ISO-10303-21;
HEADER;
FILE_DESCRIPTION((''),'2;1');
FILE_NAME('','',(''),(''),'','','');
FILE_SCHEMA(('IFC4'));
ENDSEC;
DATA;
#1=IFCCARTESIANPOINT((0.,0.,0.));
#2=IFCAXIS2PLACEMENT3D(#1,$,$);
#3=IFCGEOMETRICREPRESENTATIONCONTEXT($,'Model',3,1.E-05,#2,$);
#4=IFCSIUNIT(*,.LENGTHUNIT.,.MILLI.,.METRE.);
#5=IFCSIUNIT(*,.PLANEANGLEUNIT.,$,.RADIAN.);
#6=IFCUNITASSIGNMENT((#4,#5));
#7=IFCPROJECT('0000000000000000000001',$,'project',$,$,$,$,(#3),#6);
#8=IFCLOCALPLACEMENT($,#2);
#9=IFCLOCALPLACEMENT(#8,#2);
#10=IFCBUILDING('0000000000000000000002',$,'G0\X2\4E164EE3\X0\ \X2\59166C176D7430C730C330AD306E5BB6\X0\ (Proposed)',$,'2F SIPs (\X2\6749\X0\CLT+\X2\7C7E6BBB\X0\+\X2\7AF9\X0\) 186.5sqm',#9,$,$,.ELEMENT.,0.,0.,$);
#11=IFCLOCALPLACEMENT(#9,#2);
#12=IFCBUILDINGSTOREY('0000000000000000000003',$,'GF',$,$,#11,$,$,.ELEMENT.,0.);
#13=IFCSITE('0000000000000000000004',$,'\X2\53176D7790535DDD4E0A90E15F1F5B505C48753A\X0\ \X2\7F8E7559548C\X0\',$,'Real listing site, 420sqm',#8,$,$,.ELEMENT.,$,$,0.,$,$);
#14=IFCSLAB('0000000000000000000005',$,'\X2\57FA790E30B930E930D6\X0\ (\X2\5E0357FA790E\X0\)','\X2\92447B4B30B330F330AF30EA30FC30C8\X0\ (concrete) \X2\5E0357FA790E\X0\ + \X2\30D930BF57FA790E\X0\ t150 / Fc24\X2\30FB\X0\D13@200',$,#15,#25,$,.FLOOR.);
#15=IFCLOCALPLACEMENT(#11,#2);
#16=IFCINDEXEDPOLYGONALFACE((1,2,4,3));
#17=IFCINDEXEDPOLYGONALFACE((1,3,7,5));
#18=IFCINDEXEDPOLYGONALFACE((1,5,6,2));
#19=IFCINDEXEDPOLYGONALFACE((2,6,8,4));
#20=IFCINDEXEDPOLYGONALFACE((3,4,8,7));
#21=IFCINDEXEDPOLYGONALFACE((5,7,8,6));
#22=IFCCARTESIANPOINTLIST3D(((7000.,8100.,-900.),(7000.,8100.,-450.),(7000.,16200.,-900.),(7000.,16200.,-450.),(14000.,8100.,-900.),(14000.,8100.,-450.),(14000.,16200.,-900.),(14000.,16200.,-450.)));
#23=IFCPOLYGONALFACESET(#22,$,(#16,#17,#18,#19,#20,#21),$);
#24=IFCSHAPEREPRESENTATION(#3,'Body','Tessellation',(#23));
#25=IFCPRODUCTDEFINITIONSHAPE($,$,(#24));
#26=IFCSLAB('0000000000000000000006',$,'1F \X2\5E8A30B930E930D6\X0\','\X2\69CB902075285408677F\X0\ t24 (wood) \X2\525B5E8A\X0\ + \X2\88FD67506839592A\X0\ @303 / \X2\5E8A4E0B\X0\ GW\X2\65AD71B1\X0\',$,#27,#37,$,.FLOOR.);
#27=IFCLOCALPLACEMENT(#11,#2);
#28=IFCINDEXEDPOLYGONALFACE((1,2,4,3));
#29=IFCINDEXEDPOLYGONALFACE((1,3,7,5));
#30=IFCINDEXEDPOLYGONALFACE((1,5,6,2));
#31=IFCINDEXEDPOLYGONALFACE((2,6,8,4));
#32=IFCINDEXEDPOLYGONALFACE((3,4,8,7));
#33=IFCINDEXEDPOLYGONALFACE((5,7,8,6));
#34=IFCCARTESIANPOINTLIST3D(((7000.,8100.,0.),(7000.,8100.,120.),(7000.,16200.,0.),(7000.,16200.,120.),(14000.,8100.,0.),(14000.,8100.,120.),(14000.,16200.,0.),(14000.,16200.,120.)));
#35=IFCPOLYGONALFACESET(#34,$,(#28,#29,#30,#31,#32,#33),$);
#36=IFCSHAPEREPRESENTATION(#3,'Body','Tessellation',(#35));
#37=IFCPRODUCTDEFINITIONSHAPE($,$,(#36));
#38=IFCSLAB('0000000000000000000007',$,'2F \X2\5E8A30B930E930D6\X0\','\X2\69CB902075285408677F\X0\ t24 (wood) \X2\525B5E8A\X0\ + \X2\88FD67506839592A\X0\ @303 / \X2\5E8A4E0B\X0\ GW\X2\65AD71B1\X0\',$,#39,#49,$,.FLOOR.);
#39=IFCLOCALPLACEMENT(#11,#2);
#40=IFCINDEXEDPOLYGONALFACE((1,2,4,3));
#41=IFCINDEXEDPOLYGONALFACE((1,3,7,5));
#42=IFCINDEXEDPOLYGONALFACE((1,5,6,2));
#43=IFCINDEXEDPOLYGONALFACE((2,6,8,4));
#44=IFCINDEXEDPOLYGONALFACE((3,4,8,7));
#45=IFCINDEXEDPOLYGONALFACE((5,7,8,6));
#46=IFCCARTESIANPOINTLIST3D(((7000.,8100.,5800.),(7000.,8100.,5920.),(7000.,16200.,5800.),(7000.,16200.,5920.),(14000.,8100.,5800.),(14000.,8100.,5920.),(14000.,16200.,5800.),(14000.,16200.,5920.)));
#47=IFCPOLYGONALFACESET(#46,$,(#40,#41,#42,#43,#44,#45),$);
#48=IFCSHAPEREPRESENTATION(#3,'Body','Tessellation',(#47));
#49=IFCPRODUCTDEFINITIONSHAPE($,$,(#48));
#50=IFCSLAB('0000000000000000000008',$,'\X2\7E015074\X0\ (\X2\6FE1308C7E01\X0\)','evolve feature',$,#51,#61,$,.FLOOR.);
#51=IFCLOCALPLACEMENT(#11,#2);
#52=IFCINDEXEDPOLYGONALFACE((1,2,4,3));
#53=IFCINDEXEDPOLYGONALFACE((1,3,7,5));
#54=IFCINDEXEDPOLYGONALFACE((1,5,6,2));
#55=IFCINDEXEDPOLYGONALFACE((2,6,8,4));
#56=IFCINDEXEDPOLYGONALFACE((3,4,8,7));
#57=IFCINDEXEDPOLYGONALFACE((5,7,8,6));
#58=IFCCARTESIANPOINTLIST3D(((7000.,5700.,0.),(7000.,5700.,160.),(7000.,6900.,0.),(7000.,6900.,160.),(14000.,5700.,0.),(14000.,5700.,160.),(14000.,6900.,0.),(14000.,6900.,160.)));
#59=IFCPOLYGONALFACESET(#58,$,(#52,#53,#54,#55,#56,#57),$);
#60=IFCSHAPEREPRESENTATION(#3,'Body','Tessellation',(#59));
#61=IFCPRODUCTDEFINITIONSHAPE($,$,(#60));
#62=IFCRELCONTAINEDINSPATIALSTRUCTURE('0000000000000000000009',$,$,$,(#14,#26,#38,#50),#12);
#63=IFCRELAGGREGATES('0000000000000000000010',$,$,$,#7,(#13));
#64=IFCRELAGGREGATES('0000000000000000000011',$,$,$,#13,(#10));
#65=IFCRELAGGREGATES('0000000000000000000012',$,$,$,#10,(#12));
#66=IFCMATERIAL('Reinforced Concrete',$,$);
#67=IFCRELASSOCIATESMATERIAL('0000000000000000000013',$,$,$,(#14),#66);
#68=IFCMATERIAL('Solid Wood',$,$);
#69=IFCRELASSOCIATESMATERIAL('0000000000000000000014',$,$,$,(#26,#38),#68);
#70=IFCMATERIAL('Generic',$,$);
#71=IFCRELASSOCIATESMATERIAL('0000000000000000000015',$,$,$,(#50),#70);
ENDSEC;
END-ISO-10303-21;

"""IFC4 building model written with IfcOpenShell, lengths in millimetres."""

from ifc_helpers import new_model, si_unit, frame, frame_2d, origin, place, context, project, spatial, rectangle, extrude, material, element, save


model = new_model("IFC4")

# Units and contexts
model_context = context("Model", 3, precision=1e-05, world=origin())
ifc_project = project(units=[si_unit("LENGTHUNIT", "METRE", prefix="MILLI"), si_unit("PLANEANGLEUNIT", "RADIAN")], contexts=[model_context])

# Site, building, storey
site_placement = place(None, origin())
site = spatial("IfcSite", under=ifc_project, at=site_placement, Name="北海道川上郡弟子屈町 美留和", ObjectType="Real listing site, 420sqm", CompositionType="ELEMENT", RefElevation=0.0)
building_placement = place(site_placement, origin())
building = spatial("IfcBuilding", under=site, at=building_placement, Name="G0世代 外気浴デッキの家 (Proposed)", ObjectType="2F SIPs (杉CLT+籾殻+竹) 186.5sqm", CompositionType="ELEMENT", ElevationOfRefHeight=0.0, ElevationOfTerrain=0.0)
storey_placement = place(building_placement, origin())
storey = spatial("IfcBuildingStorey", under=building, at=storey_placement, Name="GF", CompositionType="ELEMENT", Elevation=0.0)

# Slabs
ifc_material_1 = material(Name="Reinforced Concrete")
slab_1_placement = place(storey_placement, frame((3500.0, 4050.0, -450.0)))
element("IfcSlab", 1, at=slab_1_placement, inside=storey, material=ifc_material_1, Name="基礎スラブ (布基礎)", Description="鉄筋コンクリート (concrete) 布基礎 + ベタ基礎 t150 / Fc24・D13@200", PredefinedType="FLOOR", context=model_context, shape_type="SweptSolid", body=[
    extrude(rectangle(XDim=7000.0, YDim=8100.0, at=frame_2d((3500.0, 4050.0))), frame((3500.0, 4050.0, -450.0)), (0.0, 0.0, 1.0), 450.0),
])
ifc_material_2 = material(Name="Solid Wood")
slab_2_placement = place(storey_placement, frame((3500.0, 4050.0, 0.0)))
element("IfcSlab", 2, at=slab_2_placement, inside=storey, material=ifc_material_2, Name="1F 床スラブ", Description="構造用合板 t24 (wood) 剛床 + 製材根太 @303 / 床下 GW断熱", PredefinedType="FLOOR", context=model_context, shape_type="SweptSolid", body=[
    extrude(rectangle(XDim=7000.0, YDim=8100.0, at=frame_2d((3500.0, 4050.0))), frame((3500.0, 4050.0, 0.0)), (0.0, 0.0, 1.0), 120.0),
])
slab_3_placement = place(storey_placement, frame((3500.0, 4050.0, 2900.0)))
element("IfcSlab", 3, at=slab_3_placement, inside=storey, material=ifc_material_2, Name="2F 床スラブ", Description="構造用合板 t24 (wood) 剛床 + 製材根太 @303 / 床下 GW断熱", PredefinedType="FLOOR", context=model_context, shape_type="SweptSolid", body=[
    extrude(rectangle(XDim=7000.0, YDim=8100.0, at=frame_2d((3500.0, 4050.0))), frame((3500.0, 4050.0, 2900.0)), (0.0, 0.0, 1.0), 120.0),
])
ifc_material_3 = material(Name="Generic")
slab_4_placement = place(storey_placement, frame((3500.0, 2850.0, 0.0)))
element("IfcSlab", 4, at=slab_4_placement, inside=storey, material=ifc_material_3, Name="縁側 (濡れ縁)", Description="evolve feature", PredefinedType="FLOOR", context=model_context, shape_type="SweptSolid", body=[
    extrude(rectangle(XDim=7000.0, YDim=1200.0, at=frame_2d((3500.0, 600.0))), frame((3500.0, 2850.0, 0.0)), (0.0, 0.0, 1.0), 160.0),
])

save(model, "model.ifc")
